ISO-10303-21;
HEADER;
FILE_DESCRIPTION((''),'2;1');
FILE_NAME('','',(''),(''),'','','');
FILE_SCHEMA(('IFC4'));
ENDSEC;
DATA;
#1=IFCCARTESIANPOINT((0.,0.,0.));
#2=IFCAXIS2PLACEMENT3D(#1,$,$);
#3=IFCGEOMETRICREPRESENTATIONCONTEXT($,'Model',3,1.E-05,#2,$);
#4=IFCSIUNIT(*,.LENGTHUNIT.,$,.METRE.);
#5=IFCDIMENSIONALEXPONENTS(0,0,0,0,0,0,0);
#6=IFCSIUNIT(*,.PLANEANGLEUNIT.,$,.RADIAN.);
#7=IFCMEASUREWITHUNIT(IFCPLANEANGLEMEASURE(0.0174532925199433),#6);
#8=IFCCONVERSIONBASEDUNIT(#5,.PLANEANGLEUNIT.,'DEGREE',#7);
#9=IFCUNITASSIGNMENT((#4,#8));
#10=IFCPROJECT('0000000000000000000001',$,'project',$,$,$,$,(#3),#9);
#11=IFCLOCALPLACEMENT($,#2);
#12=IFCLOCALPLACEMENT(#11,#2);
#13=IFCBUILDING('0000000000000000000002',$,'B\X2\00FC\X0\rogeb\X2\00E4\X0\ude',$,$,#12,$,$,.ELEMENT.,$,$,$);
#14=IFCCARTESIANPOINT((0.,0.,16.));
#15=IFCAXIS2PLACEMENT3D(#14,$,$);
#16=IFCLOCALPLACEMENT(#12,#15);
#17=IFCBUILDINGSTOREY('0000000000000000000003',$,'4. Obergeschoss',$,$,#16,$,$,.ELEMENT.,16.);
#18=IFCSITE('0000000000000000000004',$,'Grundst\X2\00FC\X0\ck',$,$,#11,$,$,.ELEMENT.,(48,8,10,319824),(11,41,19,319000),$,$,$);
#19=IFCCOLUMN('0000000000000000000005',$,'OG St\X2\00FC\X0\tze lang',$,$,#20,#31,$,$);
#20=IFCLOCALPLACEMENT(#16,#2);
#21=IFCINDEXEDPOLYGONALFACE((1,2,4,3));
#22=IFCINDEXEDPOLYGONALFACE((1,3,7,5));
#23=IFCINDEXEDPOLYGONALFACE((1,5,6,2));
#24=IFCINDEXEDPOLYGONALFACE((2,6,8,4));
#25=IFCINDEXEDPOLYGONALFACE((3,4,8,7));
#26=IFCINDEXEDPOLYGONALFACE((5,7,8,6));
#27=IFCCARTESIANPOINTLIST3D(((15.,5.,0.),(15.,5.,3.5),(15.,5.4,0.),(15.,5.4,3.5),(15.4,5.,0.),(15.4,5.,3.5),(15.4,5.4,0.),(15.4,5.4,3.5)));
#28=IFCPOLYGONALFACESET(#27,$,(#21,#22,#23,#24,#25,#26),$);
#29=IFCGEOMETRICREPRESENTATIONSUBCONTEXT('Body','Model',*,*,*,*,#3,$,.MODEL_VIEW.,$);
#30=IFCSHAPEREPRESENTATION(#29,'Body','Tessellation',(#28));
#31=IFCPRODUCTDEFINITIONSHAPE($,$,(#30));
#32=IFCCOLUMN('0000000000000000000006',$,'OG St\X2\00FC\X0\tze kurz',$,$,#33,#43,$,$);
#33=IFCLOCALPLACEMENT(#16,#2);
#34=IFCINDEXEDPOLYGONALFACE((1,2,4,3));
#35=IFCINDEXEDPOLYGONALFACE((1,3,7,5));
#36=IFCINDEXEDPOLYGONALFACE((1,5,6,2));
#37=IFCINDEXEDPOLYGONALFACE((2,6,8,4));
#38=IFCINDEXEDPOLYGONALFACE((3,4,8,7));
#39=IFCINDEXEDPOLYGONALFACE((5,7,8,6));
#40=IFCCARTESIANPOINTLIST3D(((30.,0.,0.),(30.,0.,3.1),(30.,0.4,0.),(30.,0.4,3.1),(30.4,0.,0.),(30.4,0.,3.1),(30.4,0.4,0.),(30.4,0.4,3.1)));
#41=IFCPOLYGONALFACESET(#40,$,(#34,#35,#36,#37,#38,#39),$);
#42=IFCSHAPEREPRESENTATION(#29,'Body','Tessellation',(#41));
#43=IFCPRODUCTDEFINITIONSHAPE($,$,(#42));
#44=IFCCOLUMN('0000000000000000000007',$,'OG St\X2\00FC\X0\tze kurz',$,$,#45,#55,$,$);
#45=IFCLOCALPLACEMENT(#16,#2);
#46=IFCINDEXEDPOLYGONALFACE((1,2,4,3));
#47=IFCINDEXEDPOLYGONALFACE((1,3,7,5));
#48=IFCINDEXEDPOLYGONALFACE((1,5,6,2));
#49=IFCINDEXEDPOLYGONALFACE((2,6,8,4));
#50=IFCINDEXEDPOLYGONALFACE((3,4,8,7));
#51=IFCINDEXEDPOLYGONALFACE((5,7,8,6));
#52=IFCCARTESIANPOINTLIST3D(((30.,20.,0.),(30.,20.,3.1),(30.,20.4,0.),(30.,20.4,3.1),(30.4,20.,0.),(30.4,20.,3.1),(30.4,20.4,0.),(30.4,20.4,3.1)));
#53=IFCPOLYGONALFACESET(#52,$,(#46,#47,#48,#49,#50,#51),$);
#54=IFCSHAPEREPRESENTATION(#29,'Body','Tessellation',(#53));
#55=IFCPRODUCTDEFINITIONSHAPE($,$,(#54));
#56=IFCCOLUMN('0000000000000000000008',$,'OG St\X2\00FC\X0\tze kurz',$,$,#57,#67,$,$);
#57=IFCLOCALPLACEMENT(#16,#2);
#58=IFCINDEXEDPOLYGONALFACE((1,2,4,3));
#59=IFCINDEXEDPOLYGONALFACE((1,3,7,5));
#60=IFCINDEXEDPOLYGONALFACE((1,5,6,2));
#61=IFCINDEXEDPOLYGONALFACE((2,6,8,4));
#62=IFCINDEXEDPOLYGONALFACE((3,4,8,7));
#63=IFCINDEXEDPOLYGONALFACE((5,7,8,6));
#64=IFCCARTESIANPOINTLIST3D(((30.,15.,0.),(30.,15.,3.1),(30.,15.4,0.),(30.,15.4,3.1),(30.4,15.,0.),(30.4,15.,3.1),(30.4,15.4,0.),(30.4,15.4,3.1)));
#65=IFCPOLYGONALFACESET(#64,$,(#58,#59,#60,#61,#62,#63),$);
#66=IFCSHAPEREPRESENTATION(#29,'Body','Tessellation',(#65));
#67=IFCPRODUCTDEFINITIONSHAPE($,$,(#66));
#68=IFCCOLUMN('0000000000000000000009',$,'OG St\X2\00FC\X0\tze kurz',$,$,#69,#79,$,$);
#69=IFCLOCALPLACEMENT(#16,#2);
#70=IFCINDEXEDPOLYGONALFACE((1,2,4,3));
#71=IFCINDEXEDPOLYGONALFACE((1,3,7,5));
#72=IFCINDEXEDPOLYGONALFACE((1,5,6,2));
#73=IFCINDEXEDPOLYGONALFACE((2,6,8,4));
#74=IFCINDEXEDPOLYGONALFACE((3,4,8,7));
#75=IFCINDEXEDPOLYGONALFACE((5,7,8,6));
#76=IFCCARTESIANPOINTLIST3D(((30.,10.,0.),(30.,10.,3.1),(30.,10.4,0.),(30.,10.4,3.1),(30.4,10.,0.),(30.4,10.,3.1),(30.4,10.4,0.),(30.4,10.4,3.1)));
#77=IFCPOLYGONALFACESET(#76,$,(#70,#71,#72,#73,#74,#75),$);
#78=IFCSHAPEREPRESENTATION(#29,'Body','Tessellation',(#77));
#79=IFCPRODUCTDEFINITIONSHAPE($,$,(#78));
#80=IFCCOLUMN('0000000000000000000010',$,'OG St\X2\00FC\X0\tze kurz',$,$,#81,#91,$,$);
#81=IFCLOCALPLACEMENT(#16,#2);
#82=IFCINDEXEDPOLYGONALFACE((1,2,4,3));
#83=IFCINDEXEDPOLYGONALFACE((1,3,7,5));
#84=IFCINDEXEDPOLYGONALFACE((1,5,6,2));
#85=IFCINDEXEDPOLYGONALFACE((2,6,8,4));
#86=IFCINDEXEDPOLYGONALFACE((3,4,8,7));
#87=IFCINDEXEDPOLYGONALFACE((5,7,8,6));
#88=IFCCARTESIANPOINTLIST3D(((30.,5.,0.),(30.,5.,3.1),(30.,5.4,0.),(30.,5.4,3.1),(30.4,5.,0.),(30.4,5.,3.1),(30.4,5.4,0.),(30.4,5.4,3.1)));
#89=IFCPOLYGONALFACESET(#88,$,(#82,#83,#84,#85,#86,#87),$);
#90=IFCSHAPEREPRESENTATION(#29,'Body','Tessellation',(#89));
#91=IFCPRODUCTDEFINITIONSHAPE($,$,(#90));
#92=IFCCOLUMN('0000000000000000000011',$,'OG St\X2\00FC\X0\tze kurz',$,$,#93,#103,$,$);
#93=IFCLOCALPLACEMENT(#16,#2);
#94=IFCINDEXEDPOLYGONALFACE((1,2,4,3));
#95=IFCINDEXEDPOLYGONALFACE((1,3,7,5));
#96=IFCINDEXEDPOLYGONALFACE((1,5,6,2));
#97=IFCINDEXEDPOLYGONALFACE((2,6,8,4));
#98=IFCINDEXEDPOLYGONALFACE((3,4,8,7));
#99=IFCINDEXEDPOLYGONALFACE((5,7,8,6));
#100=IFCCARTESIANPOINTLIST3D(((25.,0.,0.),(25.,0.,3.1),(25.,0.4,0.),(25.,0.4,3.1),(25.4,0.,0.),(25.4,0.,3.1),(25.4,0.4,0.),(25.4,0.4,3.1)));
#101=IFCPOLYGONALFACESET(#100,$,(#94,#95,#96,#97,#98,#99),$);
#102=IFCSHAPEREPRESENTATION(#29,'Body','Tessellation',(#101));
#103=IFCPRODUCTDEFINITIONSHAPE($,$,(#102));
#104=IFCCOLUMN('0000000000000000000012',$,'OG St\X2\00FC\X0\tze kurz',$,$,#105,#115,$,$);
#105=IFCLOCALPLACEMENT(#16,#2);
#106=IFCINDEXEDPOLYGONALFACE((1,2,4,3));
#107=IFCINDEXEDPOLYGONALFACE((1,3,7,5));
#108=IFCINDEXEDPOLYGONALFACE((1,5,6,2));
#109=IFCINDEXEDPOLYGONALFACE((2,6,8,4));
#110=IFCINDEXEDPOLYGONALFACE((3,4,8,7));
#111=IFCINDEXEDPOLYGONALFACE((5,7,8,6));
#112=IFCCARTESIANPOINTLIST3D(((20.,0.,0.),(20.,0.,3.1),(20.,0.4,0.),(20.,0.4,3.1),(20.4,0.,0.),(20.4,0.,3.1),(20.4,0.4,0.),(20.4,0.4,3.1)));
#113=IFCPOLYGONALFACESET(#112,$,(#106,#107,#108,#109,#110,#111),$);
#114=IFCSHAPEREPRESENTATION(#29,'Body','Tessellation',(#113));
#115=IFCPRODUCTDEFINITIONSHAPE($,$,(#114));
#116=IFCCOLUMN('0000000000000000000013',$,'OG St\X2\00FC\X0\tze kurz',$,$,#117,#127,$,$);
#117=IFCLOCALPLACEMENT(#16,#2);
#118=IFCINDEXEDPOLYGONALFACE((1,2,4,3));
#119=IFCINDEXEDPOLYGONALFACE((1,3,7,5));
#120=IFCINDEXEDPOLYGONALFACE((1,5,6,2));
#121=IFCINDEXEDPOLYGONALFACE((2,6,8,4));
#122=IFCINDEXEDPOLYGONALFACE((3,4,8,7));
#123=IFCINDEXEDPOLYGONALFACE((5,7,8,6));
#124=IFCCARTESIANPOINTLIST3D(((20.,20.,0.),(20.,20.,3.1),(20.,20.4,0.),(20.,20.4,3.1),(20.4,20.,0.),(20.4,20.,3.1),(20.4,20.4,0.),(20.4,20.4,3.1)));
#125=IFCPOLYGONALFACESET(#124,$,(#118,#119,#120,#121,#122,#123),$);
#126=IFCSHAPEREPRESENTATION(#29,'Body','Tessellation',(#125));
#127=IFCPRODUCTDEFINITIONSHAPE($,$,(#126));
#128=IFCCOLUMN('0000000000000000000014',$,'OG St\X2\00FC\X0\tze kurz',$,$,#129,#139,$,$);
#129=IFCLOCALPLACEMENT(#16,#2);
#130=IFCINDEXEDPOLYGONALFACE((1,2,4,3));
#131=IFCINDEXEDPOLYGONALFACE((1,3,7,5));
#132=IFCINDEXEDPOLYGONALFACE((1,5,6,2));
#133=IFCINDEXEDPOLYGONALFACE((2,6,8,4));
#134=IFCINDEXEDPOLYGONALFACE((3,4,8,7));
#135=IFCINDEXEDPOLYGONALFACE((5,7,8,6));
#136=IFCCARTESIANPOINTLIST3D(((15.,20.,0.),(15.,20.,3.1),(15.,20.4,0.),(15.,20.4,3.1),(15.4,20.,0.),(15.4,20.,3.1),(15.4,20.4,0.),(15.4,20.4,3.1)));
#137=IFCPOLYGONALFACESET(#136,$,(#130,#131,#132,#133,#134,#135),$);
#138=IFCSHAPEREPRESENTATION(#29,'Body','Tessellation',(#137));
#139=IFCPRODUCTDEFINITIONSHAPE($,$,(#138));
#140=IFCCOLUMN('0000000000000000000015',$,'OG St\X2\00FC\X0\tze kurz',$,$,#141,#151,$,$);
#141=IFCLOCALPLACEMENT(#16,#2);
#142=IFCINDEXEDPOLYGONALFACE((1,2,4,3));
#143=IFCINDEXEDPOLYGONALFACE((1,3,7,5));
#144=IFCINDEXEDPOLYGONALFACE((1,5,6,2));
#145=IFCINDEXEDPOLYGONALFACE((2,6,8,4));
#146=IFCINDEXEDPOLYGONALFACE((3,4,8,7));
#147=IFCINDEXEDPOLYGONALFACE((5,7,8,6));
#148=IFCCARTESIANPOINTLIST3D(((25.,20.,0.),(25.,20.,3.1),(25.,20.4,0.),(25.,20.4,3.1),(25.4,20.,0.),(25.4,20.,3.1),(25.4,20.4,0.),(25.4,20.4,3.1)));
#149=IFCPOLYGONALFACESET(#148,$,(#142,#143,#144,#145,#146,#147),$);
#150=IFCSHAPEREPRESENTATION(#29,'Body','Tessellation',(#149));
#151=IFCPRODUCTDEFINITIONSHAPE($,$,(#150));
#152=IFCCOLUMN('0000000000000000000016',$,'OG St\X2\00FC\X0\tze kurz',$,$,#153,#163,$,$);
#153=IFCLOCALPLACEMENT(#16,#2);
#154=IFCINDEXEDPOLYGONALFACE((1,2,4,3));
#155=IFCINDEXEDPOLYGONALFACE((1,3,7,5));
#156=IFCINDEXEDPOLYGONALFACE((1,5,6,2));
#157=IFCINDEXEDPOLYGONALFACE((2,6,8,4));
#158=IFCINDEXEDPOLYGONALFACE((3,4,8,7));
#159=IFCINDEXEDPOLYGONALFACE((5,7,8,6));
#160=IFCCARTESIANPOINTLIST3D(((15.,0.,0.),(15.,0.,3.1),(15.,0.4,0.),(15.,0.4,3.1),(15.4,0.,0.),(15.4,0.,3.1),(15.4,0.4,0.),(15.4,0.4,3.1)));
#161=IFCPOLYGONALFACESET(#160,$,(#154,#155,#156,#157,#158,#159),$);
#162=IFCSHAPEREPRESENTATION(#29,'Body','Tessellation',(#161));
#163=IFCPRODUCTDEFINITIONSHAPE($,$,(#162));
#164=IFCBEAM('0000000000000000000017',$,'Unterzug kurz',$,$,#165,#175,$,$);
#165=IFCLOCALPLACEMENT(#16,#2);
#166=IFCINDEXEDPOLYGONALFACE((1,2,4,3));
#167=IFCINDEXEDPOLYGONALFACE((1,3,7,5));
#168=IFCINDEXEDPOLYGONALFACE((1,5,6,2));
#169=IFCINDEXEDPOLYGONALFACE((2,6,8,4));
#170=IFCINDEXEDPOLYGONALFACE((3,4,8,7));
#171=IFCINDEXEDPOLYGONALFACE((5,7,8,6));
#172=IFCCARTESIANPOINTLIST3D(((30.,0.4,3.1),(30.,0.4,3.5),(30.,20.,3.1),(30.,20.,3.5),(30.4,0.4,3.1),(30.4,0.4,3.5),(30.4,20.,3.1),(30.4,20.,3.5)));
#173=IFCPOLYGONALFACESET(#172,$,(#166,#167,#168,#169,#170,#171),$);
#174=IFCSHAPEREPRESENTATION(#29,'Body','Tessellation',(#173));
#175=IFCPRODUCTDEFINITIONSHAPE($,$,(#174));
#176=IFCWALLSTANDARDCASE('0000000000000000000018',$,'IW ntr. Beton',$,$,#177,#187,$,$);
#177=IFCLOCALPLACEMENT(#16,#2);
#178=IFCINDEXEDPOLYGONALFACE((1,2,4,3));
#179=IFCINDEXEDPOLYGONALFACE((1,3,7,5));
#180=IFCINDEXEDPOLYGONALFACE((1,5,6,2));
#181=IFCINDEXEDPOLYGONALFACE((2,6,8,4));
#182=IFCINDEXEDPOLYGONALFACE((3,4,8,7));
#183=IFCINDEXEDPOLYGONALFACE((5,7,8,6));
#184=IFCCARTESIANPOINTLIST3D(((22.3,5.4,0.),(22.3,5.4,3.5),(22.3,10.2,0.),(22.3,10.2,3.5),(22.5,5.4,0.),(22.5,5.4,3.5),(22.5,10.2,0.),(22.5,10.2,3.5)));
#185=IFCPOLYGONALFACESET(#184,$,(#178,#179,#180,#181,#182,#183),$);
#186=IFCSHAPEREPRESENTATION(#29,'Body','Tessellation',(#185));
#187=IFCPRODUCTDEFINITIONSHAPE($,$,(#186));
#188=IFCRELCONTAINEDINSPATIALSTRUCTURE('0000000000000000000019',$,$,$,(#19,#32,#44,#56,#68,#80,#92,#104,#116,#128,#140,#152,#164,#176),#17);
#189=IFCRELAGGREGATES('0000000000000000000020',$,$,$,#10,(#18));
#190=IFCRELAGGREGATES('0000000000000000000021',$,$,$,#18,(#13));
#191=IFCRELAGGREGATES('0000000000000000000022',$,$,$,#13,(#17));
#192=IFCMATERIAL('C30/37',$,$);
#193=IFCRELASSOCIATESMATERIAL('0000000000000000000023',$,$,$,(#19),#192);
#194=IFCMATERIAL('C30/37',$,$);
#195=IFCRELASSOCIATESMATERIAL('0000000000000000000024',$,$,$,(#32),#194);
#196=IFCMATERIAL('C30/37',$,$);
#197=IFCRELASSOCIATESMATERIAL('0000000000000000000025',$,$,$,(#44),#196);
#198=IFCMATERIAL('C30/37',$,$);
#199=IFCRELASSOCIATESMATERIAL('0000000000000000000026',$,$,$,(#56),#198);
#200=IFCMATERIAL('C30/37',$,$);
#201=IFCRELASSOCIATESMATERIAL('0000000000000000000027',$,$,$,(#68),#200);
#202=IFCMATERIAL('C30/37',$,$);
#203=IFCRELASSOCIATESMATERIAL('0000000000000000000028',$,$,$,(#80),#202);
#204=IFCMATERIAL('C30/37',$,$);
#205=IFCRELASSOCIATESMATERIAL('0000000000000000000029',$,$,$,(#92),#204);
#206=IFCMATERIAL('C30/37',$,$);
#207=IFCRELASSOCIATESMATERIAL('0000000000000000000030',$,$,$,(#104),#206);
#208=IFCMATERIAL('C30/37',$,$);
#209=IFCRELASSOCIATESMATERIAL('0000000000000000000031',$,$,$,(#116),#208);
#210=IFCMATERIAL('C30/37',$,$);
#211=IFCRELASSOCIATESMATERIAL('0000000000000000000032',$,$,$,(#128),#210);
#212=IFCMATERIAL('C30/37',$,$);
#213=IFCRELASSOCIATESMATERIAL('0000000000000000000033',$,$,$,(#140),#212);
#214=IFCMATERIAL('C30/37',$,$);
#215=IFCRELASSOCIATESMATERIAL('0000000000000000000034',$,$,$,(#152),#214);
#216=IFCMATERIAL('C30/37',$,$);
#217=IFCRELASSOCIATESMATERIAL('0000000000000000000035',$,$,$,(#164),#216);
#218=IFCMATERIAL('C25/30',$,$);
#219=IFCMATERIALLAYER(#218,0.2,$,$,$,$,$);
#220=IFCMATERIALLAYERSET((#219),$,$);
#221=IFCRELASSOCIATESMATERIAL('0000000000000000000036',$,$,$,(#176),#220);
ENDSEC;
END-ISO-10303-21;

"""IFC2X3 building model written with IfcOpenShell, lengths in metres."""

from ifc_helpers import new_model, entity, si_unit, converted_unit, frame, frame_2d, origin, origin_with_axes, place, context, subcontext, project, spatial, rectangle, extrude, material, layer, layer_set, layer_usage, element, save


model = new_model("IFC2X3")

# Units and contexts
model_context = context("Model", 3, precision=1e-05, world=origin())
body_context = subcontext(model_context, "Body", "Model", "MODEL_VIEW")
ifc_project = project(units=[si_unit("LENGTHUNIT", "METRE"), converted_unit("PLANEANGLEUNIT", "DEGREE", entity("IfcPlaneAngleMeasure", 0.0174532925199433), si_unit("PLANEANGLEUNIT", "RADIAN"), dimensions=[0, 0, 0, 0, 0, 0, 0])], contexts=[model_context])

# Site, building, storey
site_placement = place(None, origin())
site = spatial("IfcSite", under=ifc_project, at=site_placement, Name="Grundstück", CompositionType="ELEMENT", RefLatitude=(48, 8, 10, 319824), RefLongitude=(11, 41, 19, 319000))
building_placement = place(site_placement, origin())
building = spatial("IfcBuilding", under=site, at=building_placement, Name="Bürogebäude", CompositionType="ELEMENT")
storey_placement = place(building_placement, frame((0.0, 0.0, 16.0)))
storey = spatial("IfcBuildingStorey", under=building, at=storey_placement, Name="4. Obergeschoss", CompositionType="ELEMENT", Elevation=16.0)

# Columns
ifc_material_1 = material(Name="C30/37")
column_1_placement = place(storey_placement, frame((15.0, 5.0, 0.0)))
element("IfcColumn", 1, at=column_1_placement, inside=storey, material=ifc_material_1, Name="OG Stütze lang", context=body_context, shape_type="SweptSolid", body=[
    extrude(rectangle(XDim=0.4, YDim=0.4, at=frame_2d((0.2, 0.2), x_axis=(1.0, 0.0))), origin_with_axes(), (0.0, 0.0, 1.0), 3.5),
])
ifc_material_2 = material(Name="C30/37")
column_2_placement = place(storey_placement, frame((30.0, 0.0, 0.0)))
element("IfcColumn", 2, at=column_2_placement, inside=storey, material=ifc_material_2, Name="OG Stütze kurz", context=body_context, shape_type="SweptSolid", body=[
    extrude(rectangle(XDim=0.4, YDim=0.4, at=frame_2d((0.2, 0.2), x_axis=(1.0, 0.0))), origin_with_axes(), (0.0, 0.0, 1.0), 3.1),
])
ifc_material_3 = material(Name="C30/37")
column_3_placement = place(storey_placement, frame((30.0, 20.0, 0.0)))
element("IfcColumn", 3, at=column_3_placement, inside=storey, material=ifc_material_3, Name="OG Stütze kurz", context=body_context, shape_type="SweptSolid", body=[
    extrude(rectangle(XDim=0.4, YDim=0.4, at=frame_2d((0.2, 0.2), x_axis=(1.0, 0.0))), origin_with_axes(), (0.0, 0.0, 1.0), 3.1),
])
ifc_material_4 = material(Name="C30/37")
column_4_placement = place(storey_placement, frame((30.0, 15.0, 0.0)))
element("IfcColumn", 4, at=column_4_placement, inside=storey, material=ifc_material_4, Name="OG Stütze kurz", context=body_context, shape_type="SweptSolid", body=[
    extrude(rectangle(XDim=0.4, YDim=0.4, at=frame_2d((0.2, 0.2), x_axis=(1.0, 0.0))), origin_with_axes(), (0.0, 0.0, 1.0), 3.1),
])
ifc_material_5 = material(Name="C30/37")
column_5_placement = place(storey_placement, frame((30.0, 10.0, 0.0)))
element("IfcColumn", 5, at=column_5_placement, inside=storey, material=ifc_material_5, Name="OG Stütze kurz", context=body_context, shape_type="SweptSolid", body=[
    extrude(rectangle(XDim=0.4, YDim=0.4, at=frame_2d((0.2, 0.2), x_axis=(1.0, 0.0))), origin_with_axes(), (0.0, 0.0, 1.0), 3.1),
])
ifc_material_6 = material(Name="C30/37")
column_6_placement = place(storey_placement, frame((30.0, 5.0, 0.0)))
element("IfcColumn", 6, at=column_6_placement, inside=storey, material=ifc_material_6, Name="OG Stütze kurz", context=body_context, shape_type="SweptSolid", body=[
    extrude(rectangle(XDim=0.4, YDim=0.4, at=frame_2d((0.2, 0.2), x_axis=(1.0, 0.0))), origin_with_axes(), (0.0, 0.0, 1.0), 3.1),
])
ifc_material_7 = material(Name="C30/37")
column_7_placement = place(storey_placement, frame((25.0, 0.0, 0.0)))
element("IfcColumn", 7, at=column_7_placement, inside=storey, material=ifc_material_7, Name="OG Stütze kurz", context=body_context, shape_type="SweptSolid", body=[
    extrude(rectangle(XDim=0.4, YDim=0.4, at=frame_2d((0.2, 0.2), x_axis=(1.0, 0.0))), origin_with_axes(), (0.0, 0.0, 1.0), 3.1),
])
ifc_material_8 = material(Name="C30/37")
column_8_placement = place(storey_placement, frame((20.0, 0.0, 0.0)))
element("IfcColumn", 8, at=column_8_placement, inside=storey, material=ifc_material_8, Name="OG Stütze kurz", context=body_context, shape_type="SweptSolid", body=[
    extrude(rectangle(XDim=0.4, YDim=0.4, at=frame_2d((0.2, 0.2), x_axis=(1.0, 0.0))), origin_with_axes(), (0.0, 0.0, 1.0), 3.1),
])
ifc_material_9 = material(Name="C30/37")
column_9_placement = place(storey_placement, frame((20.0, 20.0, 0.0)))
element("IfcColumn", 9, at=column_9_placement, inside=storey, material=ifc_material_9, Name="OG Stütze kurz", context=body_context, shape_type="SweptSolid", body=[
    extrude(rectangle(XDim=0.4, YDim=0.4, at=frame_2d((0.2, 0.2), x_axis=(1.0, 0.0))), origin_with_axes(), (0.0, 0.0, 1.0), 3.1),
])
ifc_material_10 = material(Name="C30/37")
column_10_placement = place(storey_placement, frame((15.0, 20.0, 0.0)))
element("IfcColumn", 10, at=column_10_placement, inside=storey, material=ifc_material_10, Name="OG Stütze kurz", context=body_context, shape_type="SweptSolid", body=[
    extrude(rectangle(XDim=0.4, YDim=0.4, at=frame_2d((0.2, 0.2), x_axis=(1.0, 0.0))), origin_with_axes(), (0.0, 0.0, 1.0), 3.1),
])
ifc_material_11 = material(Name="C30/37")
column_11_placement = place(storey_placement, frame((25.0, 20.0, 0.0)))
element("IfcColumn", 11, at=column_11_placement, inside=storey, material=ifc_material_11, Name="OG Stütze kurz", context=body_context, shape_type="SweptSolid", body=[
    extrude(rectangle(XDim=0.4, YDim=0.4, at=frame_2d((0.2, 0.2), x_axis=(1.0, 0.0))), origin_with_axes(), (0.0, 0.0, 1.0), 3.1),
])
ifc_material_12 = material(Name="C30/37")
column_12_placement = place(storey_placement, frame((15.0, 0.0, 0.0)))
element("IfcColumn", 12, at=column_12_placement, inside=storey, material=ifc_material_12, Name="OG Stütze kurz", context=body_context, shape_type="SweptSolid", body=[
    extrude(rectangle(XDim=0.4, YDim=0.4, at=frame_2d((0.2, 0.2), x_axis=(1.0, 0.0))), origin_with_axes(), (0.0, 0.0, 1.0), 3.1),
])

# Beam
ifc_material_13 = material(Name="C30/37")
beam_placement = place(storey_placement, frame((30.4, 0.4, 3.1), z_axis=(0.0, 0.0, 1.0), x_axis=(0.0, 1.0, 0.0)))
element("IfcBeam", 13, at=beam_placement, inside=storey, material=ifc_material_13, Name="Unterzug kurz", context=body_context, shape_type="SweptSolid", body=[
    extrude(rectangle(XDim=0.4, YDim=0.4, at=frame_2d((0.2, 0.2), x_axis=(1.0, 0.0))), frame((0.0, 0.0, 0.0), z_axis=(1.0, 0.0, 0.0), x_axis=(0.0, 1.0, 0.0)), (0.0, 0.0, 1.0), 19.6),
])

# Wall
ifc_material_14 = material(Name="C25/30")
ifc_layer_1 = layer(ifc_material_14, 0.2)
ifc_layer_set_1 = layer_set([ifc_layer_1])
ifc_layer_usage_1 = layer_usage(ifc_layer_set_1, "AXIS2", "POSITIVE", -0.2)
wall_1_placement = place(storey_placement, frame((22.3, 10.2, 0.0), z_axis=(0.0, 0.0, 1.0), x_axis=(0.0, -1.0, 0.0)))
element("IfcWallStandardCase", 14, at=wall_1_placement, inside=storey, material=ifc_layer_usage_1, Name="IW ntr. Beton", context=body_context, shape_type="SweptSolid", body=[
    extrude(rectangle(XDim=4.8, YDim=0.2, at=frame_2d((2.4, 0.1), x_axis=(1.0, 0.0))), origin_with_axes(), (0.0, 0.0, 1.0), 3.5),
])

save(model, "model.ifc")
